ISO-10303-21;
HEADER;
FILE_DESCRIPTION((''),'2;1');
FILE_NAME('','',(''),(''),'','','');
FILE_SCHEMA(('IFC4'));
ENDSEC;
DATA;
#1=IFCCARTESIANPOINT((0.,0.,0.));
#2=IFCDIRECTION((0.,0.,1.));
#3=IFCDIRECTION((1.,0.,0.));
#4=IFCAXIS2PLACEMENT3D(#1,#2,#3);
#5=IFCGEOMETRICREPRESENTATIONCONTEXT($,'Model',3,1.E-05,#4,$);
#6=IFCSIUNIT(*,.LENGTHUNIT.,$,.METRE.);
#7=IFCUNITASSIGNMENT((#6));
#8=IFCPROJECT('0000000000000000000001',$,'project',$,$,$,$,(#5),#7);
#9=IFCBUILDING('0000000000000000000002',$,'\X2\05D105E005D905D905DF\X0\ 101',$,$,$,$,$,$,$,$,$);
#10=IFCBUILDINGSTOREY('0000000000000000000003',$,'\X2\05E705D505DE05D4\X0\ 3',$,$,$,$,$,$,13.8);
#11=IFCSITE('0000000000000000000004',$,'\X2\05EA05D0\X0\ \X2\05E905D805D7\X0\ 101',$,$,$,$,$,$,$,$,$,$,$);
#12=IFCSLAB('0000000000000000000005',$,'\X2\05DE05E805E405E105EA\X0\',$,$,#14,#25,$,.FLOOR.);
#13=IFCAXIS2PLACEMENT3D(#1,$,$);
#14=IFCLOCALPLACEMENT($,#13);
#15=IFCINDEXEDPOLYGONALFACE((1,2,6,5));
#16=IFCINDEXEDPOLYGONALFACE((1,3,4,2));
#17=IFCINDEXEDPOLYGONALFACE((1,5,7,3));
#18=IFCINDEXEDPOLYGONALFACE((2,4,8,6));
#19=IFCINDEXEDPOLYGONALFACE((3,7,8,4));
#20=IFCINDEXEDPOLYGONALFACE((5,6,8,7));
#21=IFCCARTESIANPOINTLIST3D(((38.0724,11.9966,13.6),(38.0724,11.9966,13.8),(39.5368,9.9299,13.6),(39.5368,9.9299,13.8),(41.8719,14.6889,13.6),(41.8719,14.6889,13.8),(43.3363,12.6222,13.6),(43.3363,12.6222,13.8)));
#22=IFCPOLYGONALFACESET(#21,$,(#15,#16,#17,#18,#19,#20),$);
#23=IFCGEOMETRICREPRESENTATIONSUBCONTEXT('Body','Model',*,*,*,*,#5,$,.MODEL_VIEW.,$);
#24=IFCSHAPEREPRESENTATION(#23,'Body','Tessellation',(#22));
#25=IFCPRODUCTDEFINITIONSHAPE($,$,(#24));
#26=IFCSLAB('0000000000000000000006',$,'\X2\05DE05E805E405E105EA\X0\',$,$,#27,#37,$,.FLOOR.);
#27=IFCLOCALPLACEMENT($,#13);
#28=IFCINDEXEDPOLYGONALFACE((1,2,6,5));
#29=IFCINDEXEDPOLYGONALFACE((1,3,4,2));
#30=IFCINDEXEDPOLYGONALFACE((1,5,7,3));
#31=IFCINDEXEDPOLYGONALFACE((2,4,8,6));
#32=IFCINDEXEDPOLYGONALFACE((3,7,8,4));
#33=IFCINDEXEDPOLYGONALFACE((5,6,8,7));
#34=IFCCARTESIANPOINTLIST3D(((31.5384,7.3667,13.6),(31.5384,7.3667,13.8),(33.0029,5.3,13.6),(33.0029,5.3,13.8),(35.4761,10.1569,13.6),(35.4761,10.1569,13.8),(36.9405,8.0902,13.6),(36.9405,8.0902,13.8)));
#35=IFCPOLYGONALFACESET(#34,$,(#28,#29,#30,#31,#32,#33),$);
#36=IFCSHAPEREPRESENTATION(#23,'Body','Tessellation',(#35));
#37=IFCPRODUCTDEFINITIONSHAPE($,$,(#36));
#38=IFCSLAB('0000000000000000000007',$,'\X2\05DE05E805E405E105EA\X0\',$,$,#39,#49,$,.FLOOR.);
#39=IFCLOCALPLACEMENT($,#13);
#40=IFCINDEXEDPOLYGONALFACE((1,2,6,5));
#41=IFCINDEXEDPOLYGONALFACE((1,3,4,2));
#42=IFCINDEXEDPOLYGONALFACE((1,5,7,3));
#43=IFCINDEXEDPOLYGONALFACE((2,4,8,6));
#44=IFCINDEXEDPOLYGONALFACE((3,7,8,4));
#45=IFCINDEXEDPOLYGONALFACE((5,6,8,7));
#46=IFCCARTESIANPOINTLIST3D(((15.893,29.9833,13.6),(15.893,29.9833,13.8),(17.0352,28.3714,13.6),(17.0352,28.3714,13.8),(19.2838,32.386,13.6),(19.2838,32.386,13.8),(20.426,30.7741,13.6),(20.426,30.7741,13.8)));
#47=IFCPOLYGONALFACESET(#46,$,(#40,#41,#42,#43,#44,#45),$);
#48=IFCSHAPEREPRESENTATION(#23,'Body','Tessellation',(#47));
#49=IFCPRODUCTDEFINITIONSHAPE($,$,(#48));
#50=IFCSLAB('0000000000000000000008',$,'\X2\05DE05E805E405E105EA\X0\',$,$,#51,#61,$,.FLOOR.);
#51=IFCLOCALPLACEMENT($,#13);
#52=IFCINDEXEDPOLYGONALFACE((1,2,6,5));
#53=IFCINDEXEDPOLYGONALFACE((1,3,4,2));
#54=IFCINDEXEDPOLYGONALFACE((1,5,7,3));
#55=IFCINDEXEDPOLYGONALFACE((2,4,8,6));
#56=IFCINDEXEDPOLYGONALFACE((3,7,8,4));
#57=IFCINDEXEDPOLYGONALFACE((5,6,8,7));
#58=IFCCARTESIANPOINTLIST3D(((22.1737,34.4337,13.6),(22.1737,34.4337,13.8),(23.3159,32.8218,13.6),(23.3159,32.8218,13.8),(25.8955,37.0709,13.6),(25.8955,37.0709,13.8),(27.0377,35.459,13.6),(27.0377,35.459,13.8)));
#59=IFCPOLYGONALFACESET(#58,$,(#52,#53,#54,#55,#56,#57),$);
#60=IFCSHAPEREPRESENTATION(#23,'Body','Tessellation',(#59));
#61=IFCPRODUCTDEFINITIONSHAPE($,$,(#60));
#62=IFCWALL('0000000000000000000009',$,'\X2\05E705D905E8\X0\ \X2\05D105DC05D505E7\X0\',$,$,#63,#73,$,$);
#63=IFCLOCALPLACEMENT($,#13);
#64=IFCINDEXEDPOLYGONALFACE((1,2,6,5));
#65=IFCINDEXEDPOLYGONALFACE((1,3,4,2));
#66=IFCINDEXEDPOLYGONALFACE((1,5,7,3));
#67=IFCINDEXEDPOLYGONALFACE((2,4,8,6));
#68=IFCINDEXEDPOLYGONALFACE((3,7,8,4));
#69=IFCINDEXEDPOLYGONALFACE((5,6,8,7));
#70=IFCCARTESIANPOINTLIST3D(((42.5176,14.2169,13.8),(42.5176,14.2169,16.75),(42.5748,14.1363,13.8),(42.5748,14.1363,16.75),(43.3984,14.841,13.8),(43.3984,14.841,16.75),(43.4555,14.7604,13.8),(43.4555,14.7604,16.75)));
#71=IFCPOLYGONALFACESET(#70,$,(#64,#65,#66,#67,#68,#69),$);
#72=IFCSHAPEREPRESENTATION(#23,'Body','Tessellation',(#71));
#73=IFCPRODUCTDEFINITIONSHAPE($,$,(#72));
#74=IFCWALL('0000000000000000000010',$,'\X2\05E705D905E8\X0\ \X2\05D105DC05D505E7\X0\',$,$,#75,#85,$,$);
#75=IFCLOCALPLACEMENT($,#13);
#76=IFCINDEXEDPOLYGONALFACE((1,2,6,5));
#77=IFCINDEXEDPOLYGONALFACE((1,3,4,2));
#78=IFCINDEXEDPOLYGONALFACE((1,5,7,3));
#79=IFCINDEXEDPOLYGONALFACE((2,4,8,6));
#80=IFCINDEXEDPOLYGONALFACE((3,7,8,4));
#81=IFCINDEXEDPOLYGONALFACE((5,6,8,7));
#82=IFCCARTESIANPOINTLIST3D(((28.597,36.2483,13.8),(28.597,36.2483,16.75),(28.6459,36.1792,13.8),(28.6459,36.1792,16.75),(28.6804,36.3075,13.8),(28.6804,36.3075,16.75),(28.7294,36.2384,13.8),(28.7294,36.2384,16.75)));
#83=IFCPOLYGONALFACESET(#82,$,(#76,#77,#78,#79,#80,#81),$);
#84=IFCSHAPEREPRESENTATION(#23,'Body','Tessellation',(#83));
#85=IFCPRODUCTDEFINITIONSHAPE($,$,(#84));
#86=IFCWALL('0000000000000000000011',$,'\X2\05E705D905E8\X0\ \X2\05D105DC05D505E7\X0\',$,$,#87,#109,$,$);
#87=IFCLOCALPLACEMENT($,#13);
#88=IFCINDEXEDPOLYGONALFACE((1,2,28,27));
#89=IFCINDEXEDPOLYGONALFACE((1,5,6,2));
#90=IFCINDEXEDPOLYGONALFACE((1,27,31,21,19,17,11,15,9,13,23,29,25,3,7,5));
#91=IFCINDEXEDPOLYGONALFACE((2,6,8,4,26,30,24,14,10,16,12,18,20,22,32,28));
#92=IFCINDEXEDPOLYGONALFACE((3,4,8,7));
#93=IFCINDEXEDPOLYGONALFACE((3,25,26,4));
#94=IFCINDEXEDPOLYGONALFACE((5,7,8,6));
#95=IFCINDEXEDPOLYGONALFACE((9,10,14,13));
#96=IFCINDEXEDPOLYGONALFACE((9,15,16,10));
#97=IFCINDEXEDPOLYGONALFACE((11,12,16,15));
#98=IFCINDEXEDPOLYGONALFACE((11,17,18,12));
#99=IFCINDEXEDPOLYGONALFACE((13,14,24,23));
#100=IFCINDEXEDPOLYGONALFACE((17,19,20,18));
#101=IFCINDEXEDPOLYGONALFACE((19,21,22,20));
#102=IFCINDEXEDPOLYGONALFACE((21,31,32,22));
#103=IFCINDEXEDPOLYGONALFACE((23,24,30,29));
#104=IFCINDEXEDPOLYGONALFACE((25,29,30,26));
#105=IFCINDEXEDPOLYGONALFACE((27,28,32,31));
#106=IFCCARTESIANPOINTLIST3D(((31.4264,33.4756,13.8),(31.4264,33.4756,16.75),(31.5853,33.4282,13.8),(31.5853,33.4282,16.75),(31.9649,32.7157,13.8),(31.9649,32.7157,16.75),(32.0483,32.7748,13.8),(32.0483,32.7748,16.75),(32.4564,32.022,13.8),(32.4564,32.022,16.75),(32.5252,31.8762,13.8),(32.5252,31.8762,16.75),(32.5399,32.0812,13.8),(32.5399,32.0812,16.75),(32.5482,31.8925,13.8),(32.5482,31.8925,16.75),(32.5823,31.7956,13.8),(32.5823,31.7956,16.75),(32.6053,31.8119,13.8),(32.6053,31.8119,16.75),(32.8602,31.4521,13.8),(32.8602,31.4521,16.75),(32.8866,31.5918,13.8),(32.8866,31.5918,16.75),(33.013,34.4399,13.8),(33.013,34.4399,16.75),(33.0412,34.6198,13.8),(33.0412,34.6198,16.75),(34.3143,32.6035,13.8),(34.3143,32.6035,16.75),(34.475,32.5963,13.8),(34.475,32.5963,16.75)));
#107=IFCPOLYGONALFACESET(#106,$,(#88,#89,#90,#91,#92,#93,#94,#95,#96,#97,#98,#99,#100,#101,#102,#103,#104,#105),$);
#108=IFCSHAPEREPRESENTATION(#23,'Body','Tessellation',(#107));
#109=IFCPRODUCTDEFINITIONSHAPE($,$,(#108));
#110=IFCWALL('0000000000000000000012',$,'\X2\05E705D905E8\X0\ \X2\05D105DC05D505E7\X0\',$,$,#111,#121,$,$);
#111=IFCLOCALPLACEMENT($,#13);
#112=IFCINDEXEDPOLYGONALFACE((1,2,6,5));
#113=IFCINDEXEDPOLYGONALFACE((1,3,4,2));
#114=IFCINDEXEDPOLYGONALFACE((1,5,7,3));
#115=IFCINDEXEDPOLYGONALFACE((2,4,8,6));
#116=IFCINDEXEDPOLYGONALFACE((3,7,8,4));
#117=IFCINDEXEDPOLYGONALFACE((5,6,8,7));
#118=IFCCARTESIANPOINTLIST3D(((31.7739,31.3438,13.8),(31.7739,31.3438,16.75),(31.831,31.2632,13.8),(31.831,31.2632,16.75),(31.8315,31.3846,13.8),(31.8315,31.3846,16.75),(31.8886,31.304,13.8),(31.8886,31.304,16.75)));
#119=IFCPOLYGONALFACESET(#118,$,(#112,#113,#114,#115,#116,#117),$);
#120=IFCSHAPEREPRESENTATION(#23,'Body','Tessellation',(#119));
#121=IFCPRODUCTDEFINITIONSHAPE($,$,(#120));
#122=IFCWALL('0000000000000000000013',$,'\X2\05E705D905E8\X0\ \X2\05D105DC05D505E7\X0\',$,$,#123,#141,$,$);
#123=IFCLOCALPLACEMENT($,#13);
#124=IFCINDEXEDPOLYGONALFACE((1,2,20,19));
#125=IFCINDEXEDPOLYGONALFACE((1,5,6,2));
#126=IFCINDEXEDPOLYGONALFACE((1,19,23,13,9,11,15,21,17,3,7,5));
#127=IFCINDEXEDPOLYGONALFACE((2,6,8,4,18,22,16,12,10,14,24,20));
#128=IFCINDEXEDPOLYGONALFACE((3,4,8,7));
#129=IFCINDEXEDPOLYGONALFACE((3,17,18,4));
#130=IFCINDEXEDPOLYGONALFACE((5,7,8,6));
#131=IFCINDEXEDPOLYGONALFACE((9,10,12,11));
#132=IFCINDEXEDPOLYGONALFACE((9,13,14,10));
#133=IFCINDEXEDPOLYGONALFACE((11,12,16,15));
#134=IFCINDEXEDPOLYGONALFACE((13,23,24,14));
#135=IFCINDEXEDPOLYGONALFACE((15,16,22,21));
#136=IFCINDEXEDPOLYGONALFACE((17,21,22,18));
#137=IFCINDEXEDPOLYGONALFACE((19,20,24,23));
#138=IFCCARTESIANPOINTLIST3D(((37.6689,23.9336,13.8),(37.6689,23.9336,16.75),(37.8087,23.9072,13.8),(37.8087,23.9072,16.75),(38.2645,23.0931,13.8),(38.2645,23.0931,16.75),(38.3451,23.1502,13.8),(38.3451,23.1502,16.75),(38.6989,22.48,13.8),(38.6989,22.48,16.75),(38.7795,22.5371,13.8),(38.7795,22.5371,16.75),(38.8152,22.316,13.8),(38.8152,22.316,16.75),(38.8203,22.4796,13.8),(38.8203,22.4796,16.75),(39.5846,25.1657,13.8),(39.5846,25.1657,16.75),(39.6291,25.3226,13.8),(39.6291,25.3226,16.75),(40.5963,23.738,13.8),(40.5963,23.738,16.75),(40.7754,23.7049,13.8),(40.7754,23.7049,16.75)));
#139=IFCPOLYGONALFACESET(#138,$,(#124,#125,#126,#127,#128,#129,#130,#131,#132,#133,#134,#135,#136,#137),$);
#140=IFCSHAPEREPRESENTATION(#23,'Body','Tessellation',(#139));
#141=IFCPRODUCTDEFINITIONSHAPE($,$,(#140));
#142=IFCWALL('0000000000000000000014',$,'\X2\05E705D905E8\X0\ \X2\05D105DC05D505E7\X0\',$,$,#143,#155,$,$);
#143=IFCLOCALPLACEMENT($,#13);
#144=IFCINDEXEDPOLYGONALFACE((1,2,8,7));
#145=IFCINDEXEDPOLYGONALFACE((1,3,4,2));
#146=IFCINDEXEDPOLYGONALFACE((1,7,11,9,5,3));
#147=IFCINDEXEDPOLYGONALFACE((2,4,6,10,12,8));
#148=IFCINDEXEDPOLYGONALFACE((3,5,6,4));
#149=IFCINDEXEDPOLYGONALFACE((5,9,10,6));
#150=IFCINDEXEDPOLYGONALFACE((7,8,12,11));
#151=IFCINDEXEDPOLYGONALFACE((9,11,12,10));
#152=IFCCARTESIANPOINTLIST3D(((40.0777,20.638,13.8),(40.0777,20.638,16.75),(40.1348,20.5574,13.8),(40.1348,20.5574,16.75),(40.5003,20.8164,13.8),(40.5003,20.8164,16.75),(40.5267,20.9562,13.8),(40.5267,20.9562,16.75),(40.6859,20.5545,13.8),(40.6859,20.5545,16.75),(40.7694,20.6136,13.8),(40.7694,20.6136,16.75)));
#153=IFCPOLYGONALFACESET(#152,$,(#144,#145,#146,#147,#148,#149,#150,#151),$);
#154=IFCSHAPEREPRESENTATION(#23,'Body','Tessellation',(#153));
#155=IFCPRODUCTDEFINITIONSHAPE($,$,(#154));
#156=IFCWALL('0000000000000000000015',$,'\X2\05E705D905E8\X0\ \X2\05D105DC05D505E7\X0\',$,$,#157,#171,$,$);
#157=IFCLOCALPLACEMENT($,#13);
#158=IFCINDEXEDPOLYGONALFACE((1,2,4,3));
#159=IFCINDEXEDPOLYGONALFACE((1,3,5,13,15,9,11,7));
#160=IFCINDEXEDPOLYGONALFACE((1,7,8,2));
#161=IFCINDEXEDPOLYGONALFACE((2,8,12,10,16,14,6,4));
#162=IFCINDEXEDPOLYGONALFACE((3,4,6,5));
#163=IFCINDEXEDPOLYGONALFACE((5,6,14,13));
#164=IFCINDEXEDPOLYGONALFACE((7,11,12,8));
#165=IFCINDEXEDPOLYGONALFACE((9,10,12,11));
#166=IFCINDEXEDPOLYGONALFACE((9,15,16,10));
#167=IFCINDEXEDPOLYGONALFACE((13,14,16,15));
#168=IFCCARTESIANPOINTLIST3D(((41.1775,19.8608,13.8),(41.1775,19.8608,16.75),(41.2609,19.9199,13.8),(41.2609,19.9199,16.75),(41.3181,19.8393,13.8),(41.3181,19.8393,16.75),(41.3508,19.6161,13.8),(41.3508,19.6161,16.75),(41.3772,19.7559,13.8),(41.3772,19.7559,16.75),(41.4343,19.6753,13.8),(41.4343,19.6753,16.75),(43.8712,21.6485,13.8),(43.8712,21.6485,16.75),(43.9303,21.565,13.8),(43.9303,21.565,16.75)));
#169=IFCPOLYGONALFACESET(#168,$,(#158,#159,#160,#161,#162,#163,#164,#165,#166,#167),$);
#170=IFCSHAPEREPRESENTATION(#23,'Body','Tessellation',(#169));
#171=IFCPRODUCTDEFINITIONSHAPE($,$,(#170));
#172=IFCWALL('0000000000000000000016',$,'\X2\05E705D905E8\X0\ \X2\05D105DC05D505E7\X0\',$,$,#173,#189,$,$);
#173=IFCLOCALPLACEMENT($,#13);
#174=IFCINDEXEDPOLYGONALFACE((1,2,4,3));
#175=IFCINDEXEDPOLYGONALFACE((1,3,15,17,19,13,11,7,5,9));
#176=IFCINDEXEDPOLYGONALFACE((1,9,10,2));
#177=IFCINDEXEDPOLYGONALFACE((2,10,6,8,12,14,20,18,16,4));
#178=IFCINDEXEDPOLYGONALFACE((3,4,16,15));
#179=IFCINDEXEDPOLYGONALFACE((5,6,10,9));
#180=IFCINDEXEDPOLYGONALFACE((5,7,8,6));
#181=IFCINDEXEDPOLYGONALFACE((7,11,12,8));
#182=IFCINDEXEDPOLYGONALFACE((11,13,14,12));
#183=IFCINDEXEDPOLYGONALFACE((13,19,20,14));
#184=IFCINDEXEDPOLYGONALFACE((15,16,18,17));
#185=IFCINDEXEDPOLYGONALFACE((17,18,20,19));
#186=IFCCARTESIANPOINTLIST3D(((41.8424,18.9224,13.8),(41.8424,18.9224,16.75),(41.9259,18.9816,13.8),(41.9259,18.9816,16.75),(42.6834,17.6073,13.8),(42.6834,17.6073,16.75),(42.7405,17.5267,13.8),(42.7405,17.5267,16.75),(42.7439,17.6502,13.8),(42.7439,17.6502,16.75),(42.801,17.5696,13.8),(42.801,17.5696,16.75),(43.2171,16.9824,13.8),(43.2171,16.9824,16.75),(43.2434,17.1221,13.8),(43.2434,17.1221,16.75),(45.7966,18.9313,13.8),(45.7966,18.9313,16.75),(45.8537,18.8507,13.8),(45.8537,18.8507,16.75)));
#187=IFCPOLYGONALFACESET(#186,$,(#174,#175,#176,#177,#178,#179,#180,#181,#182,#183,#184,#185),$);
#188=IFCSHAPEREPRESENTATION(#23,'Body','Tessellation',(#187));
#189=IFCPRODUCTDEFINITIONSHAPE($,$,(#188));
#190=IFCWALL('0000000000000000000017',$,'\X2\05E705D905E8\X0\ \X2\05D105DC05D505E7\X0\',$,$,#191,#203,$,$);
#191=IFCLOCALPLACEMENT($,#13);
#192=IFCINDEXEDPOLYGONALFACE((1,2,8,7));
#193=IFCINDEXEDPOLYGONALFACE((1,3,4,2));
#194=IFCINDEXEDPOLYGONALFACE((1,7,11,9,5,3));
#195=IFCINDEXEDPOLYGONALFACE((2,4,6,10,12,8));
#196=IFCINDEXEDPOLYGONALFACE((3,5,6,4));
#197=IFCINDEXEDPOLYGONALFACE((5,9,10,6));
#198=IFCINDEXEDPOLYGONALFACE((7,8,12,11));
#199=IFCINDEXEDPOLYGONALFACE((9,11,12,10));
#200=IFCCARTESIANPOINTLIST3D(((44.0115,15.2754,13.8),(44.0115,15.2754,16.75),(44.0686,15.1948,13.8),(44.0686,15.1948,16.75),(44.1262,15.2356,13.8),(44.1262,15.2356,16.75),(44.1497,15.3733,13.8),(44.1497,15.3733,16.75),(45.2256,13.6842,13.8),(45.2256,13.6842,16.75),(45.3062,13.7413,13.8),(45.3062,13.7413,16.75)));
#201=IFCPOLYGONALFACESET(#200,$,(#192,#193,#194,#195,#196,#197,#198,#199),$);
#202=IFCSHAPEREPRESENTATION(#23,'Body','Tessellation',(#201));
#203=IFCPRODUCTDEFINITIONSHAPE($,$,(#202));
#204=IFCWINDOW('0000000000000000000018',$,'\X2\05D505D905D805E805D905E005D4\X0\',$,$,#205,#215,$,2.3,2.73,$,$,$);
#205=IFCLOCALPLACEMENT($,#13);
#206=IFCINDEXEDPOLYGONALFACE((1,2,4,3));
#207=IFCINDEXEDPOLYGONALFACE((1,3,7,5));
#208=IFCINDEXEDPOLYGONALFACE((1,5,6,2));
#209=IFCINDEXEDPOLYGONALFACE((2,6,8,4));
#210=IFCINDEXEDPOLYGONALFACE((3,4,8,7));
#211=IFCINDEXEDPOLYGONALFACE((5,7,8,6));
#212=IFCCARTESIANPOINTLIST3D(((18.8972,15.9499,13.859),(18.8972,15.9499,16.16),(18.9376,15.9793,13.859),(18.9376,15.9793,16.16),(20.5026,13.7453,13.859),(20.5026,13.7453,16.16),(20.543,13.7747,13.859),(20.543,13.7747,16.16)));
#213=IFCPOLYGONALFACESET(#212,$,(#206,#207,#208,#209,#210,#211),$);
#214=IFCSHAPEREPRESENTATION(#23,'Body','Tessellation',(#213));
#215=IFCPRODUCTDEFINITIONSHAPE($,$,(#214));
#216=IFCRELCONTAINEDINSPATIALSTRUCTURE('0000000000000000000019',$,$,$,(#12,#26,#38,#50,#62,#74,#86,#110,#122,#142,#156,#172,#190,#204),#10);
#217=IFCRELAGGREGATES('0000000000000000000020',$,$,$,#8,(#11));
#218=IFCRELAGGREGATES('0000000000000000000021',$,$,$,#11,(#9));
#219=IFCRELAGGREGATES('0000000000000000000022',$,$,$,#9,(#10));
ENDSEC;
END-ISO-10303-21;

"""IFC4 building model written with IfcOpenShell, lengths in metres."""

from ifc_helpers import new_model, si_unit, frame, origin_with_axes, context, subcontext, project, spatial, polyline, outline, extrude, element, save


model = new_model("IFC4")

# Units and contexts
model_context = context("Model", 3, precision=1e-05, world=origin_with_axes())
body_context = subcontext(model_context, "Body", "Model", "MODEL_VIEW")
ifc_project = project(units=[si_unit("LENGTHUNIT", "METRE")], contexts=[model_context])

# Site, building, storey
site = spatial("IfcSite", under=ifc_project, Name="תא שטח 101")
building = spatial("IfcBuilding", under=site, Name="בניין 101")
storey = spatial("IfcBuildingStorey", under=building, Name="קומה 3", Elevation=13.8)

# Slabs
element("IfcSlab", 1, inside=storey, Name="מרפסת", PredefinedType="FLOOR", context=body_context, shape_type="SweptSolid", body=[
    extrude(outline(polyline([(38.0724, 11.9966), (41.8719, 14.6889), (43.3363, 12.6222), (39.5368, 9.9299), (38.0724, 11.9966)])), frame((0.0, 0.0, 13.6)), (0.0, 0.0, 1.0), 0.2),
])
element("IfcSlab", 2, inside=storey, Name="מרפסת", PredefinedType="FLOOR", context=body_context, shape_type="SweptSolid", body=[
    extrude(outline(polyline([(31.5384, 7.3667), (35.4761, 10.1569), (36.9405, 8.0902), (33.0029, 5.3), (31.5384, 7.3667)])), frame((0.0, 0.0, 13.6)), (0.0, 0.0, 1.0), 0.2),
])
element("IfcSlab", 3, inside=storey, Name="מרפסת", PredefinedType="FLOOR", context=body_context, shape_type="SweptSolid", body=[
    extrude(outline(polyline([(15.893, 29.9833), (19.2838, 32.386), (20.426, 30.7741), (17.0352, 28.3714), (15.893, 29.9833)])), frame((0.0, 0.0, 13.6)), (0.0, 0.0, 1.0), 0.2),
])
element("IfcSlab", 4, inside=storey, Name="מרפסת", PredefinedType="FLOOR", context=body_context, shape_type="SweptSolid", body=[
    extrude(outline(polyline([(22.1737, 34.4337), (25.8955, 37.0709), (27.0377, 35.459), (23.3159, 32.8218), (22.1737, 34.4337)])), frame((0.0, 0.0, 13.6)), (0.0, 0.0, 1.0), 0.2),
])

# Walls
element("IfcWall", 5, inside=storey, Name="קיר בלוק", context=body_context, shape_type="SweptSolid", body=[
    extrude(outline(polyline([(42.5176, 14.2169), (42.5748, 14.1363), (43.4555, 14.7604), (43.3984, 14.841), (42.5176, 14.2169)])), frame((0.0, 0.0, 13.8)), (0.0, 0.0, 1.0), 2.95),
])
element("IfcWall", 6, inside=storey, Name="קיר בלוק", context=body_context, shape_type="SweptSolid", body=[
    extrude(outline(polyline([(28.7294, 36.2384), (28.6804, 36.3075), (28.597, 36.2483), (28.6459, 36.1792), (28.7294, 36.2384)])), frame((0.0, 0.0, 13.8)), (0.0, 0.0, 1.0), 2.95),
])
element("IfcWall", 7, inside=storey, Name="קיר בלוק", context=body_context, shape_type="SweptSolid", body=[
    extrude(outline(polyline([(31.5853, 33.4282), (33.013, 34.4399), (34.3143, 32.6035), (32.8866, 31.5918), (32.5399, 32.0812), (32.4564, 32.022), (32.5482, 31.8925), (32.5252, 31.8762), (32.5823, 31.7956), (32.6053, 31.8119), (32.8602, 31.4521), (34.475, 32.5963), (33.0412, 34.6198), (31.4264, 33.4756), (31.9649, 32.7157), (32.0483, 32.7748), (31.5853, 33.4282)])), frame((0.0, 0.0, 13.8)), (0.0, 0.0, 1.0), 2.95),
])
element("IfcWall", 8, inside=storey, Name="קיר בלוק", context=body_context, shape_type="SweptSolid", body=[
    extrude(outline(polyline([(31.7739, 31.3438), (31.831, 31.2632), (31.8886, 31.304), (31.8315, 31.3846), (31.7739, 31.3438)])), frame((0.0, 0.0, 13.8)), (0.0, 0.0, 1.0), 2.95),
])
element("IfcWall", 9, inside=storey, Name="קיר בלוק", context=body_context, shape_type="SweptSolid", body=[
    extrude(outline(polyline([(38.3451, 23.1502), (37.8087, 23.9072), (39.5846, 25.1657), (40.5963, 23.738), (38.8203, 22.4796), (38.7795, 22.5371), (38.6989, 22.48), (38.8152, 22.316), (40.7754, 23.7049), (39.6291, 25.3226), (37.6689, 23.9336), (38.2645, 23.0931), (38.3451, 23.1502)])), frame((0.0, 0.0, 13.8)), (0.0, 0.0, 1.0), 2.95),
])
element("IfcWall", 10, inside=storey, Name="קיר בלוק", context=body_context, shape_type="SweptSolid", body=[
    extrude(outline(polyline([(40.7694, 20.6136), (40.5267, 20.9562), (40.0777, 20.638), (40.1348, 20.5574), (40.5003, 20.8164), (40.6859, 20.5545), (40.7694, 20.6136)])), frame((0.0, 0.0, 13.8)), (0.0, 0.0, 1.0), 2.95),
])
element("IfcWall", 11, inside=storey, Name="קיר בלוק", context=body_context, shape_type="SweptSolid", body=[
    extrude(outline(polyline([(41.3772, 19.7559), (43.9303, 21.565), (43.8712, 21.6485), (41.3181, 19.8393), (41.2609, 19.9199), (41.1775, 19.8608), (41.3508, 19.6161), (41.4343, 19.6753), (41.3772, 19.7559)])), frame((0.0, 0.0, 13.8)), (0.0, 0.0, 1.0), 2.95),
])
element("IfcWall", 12, inside=storey, Name="קיר בלוק", context=body_context, shape_type="SweptSolid", body=[
    extrude(outline(polyline([(42.801, 17.5696), (43.2171, 16.9824), (45.8537, 18.8507), (45.7966, 18.9313), (43.2434, 17.1221), (41.9259, 18.9816), (41.8424, 18.9224), (42.7439, 17.6502), (42.6834, 17.6073), (42.7405, 17.5267), (42.801, 17.5696)])), frame((0.0, 0.0, 13.8)), (0.0, 0.0, 1.0), 2.95),
])
element("IfcWall", 13, inside=storey, Name="קיר בלוק", context=body_context, shape_type="SweptSolid", body=[
    extrude(outline(polyline([(44.1497, 15.3733), (44.0115, 15.2754), (44.0686, 15.1948), (44.1262, 15.2356), (45.2256, 13.6842), (45.3062, 13.7413), (44.1497, 15.3733)])), frame((0.0, 0.0, 13.8)), (0.0, 0.0, 1.0), 2.95),
])

# Window
element("IfcWindow", 14, inside=storey, Name="ויטרינה", OverallHeight=2.3, OverallWidth=2.73, context=body_context, shape_type="SweptSolid", body=[
    extrude(outline(polyline([(18.8972, 15.9499), (20.5026, 13.7453), (20.543, 13.7747), (18.9376, 15.9793), (18.8972, 15.9499)])), frame((0.0, 0.0, 13.859)), (0.0, 0.0, 1.0), 2.301),
])

save(model, "model.ifc")
